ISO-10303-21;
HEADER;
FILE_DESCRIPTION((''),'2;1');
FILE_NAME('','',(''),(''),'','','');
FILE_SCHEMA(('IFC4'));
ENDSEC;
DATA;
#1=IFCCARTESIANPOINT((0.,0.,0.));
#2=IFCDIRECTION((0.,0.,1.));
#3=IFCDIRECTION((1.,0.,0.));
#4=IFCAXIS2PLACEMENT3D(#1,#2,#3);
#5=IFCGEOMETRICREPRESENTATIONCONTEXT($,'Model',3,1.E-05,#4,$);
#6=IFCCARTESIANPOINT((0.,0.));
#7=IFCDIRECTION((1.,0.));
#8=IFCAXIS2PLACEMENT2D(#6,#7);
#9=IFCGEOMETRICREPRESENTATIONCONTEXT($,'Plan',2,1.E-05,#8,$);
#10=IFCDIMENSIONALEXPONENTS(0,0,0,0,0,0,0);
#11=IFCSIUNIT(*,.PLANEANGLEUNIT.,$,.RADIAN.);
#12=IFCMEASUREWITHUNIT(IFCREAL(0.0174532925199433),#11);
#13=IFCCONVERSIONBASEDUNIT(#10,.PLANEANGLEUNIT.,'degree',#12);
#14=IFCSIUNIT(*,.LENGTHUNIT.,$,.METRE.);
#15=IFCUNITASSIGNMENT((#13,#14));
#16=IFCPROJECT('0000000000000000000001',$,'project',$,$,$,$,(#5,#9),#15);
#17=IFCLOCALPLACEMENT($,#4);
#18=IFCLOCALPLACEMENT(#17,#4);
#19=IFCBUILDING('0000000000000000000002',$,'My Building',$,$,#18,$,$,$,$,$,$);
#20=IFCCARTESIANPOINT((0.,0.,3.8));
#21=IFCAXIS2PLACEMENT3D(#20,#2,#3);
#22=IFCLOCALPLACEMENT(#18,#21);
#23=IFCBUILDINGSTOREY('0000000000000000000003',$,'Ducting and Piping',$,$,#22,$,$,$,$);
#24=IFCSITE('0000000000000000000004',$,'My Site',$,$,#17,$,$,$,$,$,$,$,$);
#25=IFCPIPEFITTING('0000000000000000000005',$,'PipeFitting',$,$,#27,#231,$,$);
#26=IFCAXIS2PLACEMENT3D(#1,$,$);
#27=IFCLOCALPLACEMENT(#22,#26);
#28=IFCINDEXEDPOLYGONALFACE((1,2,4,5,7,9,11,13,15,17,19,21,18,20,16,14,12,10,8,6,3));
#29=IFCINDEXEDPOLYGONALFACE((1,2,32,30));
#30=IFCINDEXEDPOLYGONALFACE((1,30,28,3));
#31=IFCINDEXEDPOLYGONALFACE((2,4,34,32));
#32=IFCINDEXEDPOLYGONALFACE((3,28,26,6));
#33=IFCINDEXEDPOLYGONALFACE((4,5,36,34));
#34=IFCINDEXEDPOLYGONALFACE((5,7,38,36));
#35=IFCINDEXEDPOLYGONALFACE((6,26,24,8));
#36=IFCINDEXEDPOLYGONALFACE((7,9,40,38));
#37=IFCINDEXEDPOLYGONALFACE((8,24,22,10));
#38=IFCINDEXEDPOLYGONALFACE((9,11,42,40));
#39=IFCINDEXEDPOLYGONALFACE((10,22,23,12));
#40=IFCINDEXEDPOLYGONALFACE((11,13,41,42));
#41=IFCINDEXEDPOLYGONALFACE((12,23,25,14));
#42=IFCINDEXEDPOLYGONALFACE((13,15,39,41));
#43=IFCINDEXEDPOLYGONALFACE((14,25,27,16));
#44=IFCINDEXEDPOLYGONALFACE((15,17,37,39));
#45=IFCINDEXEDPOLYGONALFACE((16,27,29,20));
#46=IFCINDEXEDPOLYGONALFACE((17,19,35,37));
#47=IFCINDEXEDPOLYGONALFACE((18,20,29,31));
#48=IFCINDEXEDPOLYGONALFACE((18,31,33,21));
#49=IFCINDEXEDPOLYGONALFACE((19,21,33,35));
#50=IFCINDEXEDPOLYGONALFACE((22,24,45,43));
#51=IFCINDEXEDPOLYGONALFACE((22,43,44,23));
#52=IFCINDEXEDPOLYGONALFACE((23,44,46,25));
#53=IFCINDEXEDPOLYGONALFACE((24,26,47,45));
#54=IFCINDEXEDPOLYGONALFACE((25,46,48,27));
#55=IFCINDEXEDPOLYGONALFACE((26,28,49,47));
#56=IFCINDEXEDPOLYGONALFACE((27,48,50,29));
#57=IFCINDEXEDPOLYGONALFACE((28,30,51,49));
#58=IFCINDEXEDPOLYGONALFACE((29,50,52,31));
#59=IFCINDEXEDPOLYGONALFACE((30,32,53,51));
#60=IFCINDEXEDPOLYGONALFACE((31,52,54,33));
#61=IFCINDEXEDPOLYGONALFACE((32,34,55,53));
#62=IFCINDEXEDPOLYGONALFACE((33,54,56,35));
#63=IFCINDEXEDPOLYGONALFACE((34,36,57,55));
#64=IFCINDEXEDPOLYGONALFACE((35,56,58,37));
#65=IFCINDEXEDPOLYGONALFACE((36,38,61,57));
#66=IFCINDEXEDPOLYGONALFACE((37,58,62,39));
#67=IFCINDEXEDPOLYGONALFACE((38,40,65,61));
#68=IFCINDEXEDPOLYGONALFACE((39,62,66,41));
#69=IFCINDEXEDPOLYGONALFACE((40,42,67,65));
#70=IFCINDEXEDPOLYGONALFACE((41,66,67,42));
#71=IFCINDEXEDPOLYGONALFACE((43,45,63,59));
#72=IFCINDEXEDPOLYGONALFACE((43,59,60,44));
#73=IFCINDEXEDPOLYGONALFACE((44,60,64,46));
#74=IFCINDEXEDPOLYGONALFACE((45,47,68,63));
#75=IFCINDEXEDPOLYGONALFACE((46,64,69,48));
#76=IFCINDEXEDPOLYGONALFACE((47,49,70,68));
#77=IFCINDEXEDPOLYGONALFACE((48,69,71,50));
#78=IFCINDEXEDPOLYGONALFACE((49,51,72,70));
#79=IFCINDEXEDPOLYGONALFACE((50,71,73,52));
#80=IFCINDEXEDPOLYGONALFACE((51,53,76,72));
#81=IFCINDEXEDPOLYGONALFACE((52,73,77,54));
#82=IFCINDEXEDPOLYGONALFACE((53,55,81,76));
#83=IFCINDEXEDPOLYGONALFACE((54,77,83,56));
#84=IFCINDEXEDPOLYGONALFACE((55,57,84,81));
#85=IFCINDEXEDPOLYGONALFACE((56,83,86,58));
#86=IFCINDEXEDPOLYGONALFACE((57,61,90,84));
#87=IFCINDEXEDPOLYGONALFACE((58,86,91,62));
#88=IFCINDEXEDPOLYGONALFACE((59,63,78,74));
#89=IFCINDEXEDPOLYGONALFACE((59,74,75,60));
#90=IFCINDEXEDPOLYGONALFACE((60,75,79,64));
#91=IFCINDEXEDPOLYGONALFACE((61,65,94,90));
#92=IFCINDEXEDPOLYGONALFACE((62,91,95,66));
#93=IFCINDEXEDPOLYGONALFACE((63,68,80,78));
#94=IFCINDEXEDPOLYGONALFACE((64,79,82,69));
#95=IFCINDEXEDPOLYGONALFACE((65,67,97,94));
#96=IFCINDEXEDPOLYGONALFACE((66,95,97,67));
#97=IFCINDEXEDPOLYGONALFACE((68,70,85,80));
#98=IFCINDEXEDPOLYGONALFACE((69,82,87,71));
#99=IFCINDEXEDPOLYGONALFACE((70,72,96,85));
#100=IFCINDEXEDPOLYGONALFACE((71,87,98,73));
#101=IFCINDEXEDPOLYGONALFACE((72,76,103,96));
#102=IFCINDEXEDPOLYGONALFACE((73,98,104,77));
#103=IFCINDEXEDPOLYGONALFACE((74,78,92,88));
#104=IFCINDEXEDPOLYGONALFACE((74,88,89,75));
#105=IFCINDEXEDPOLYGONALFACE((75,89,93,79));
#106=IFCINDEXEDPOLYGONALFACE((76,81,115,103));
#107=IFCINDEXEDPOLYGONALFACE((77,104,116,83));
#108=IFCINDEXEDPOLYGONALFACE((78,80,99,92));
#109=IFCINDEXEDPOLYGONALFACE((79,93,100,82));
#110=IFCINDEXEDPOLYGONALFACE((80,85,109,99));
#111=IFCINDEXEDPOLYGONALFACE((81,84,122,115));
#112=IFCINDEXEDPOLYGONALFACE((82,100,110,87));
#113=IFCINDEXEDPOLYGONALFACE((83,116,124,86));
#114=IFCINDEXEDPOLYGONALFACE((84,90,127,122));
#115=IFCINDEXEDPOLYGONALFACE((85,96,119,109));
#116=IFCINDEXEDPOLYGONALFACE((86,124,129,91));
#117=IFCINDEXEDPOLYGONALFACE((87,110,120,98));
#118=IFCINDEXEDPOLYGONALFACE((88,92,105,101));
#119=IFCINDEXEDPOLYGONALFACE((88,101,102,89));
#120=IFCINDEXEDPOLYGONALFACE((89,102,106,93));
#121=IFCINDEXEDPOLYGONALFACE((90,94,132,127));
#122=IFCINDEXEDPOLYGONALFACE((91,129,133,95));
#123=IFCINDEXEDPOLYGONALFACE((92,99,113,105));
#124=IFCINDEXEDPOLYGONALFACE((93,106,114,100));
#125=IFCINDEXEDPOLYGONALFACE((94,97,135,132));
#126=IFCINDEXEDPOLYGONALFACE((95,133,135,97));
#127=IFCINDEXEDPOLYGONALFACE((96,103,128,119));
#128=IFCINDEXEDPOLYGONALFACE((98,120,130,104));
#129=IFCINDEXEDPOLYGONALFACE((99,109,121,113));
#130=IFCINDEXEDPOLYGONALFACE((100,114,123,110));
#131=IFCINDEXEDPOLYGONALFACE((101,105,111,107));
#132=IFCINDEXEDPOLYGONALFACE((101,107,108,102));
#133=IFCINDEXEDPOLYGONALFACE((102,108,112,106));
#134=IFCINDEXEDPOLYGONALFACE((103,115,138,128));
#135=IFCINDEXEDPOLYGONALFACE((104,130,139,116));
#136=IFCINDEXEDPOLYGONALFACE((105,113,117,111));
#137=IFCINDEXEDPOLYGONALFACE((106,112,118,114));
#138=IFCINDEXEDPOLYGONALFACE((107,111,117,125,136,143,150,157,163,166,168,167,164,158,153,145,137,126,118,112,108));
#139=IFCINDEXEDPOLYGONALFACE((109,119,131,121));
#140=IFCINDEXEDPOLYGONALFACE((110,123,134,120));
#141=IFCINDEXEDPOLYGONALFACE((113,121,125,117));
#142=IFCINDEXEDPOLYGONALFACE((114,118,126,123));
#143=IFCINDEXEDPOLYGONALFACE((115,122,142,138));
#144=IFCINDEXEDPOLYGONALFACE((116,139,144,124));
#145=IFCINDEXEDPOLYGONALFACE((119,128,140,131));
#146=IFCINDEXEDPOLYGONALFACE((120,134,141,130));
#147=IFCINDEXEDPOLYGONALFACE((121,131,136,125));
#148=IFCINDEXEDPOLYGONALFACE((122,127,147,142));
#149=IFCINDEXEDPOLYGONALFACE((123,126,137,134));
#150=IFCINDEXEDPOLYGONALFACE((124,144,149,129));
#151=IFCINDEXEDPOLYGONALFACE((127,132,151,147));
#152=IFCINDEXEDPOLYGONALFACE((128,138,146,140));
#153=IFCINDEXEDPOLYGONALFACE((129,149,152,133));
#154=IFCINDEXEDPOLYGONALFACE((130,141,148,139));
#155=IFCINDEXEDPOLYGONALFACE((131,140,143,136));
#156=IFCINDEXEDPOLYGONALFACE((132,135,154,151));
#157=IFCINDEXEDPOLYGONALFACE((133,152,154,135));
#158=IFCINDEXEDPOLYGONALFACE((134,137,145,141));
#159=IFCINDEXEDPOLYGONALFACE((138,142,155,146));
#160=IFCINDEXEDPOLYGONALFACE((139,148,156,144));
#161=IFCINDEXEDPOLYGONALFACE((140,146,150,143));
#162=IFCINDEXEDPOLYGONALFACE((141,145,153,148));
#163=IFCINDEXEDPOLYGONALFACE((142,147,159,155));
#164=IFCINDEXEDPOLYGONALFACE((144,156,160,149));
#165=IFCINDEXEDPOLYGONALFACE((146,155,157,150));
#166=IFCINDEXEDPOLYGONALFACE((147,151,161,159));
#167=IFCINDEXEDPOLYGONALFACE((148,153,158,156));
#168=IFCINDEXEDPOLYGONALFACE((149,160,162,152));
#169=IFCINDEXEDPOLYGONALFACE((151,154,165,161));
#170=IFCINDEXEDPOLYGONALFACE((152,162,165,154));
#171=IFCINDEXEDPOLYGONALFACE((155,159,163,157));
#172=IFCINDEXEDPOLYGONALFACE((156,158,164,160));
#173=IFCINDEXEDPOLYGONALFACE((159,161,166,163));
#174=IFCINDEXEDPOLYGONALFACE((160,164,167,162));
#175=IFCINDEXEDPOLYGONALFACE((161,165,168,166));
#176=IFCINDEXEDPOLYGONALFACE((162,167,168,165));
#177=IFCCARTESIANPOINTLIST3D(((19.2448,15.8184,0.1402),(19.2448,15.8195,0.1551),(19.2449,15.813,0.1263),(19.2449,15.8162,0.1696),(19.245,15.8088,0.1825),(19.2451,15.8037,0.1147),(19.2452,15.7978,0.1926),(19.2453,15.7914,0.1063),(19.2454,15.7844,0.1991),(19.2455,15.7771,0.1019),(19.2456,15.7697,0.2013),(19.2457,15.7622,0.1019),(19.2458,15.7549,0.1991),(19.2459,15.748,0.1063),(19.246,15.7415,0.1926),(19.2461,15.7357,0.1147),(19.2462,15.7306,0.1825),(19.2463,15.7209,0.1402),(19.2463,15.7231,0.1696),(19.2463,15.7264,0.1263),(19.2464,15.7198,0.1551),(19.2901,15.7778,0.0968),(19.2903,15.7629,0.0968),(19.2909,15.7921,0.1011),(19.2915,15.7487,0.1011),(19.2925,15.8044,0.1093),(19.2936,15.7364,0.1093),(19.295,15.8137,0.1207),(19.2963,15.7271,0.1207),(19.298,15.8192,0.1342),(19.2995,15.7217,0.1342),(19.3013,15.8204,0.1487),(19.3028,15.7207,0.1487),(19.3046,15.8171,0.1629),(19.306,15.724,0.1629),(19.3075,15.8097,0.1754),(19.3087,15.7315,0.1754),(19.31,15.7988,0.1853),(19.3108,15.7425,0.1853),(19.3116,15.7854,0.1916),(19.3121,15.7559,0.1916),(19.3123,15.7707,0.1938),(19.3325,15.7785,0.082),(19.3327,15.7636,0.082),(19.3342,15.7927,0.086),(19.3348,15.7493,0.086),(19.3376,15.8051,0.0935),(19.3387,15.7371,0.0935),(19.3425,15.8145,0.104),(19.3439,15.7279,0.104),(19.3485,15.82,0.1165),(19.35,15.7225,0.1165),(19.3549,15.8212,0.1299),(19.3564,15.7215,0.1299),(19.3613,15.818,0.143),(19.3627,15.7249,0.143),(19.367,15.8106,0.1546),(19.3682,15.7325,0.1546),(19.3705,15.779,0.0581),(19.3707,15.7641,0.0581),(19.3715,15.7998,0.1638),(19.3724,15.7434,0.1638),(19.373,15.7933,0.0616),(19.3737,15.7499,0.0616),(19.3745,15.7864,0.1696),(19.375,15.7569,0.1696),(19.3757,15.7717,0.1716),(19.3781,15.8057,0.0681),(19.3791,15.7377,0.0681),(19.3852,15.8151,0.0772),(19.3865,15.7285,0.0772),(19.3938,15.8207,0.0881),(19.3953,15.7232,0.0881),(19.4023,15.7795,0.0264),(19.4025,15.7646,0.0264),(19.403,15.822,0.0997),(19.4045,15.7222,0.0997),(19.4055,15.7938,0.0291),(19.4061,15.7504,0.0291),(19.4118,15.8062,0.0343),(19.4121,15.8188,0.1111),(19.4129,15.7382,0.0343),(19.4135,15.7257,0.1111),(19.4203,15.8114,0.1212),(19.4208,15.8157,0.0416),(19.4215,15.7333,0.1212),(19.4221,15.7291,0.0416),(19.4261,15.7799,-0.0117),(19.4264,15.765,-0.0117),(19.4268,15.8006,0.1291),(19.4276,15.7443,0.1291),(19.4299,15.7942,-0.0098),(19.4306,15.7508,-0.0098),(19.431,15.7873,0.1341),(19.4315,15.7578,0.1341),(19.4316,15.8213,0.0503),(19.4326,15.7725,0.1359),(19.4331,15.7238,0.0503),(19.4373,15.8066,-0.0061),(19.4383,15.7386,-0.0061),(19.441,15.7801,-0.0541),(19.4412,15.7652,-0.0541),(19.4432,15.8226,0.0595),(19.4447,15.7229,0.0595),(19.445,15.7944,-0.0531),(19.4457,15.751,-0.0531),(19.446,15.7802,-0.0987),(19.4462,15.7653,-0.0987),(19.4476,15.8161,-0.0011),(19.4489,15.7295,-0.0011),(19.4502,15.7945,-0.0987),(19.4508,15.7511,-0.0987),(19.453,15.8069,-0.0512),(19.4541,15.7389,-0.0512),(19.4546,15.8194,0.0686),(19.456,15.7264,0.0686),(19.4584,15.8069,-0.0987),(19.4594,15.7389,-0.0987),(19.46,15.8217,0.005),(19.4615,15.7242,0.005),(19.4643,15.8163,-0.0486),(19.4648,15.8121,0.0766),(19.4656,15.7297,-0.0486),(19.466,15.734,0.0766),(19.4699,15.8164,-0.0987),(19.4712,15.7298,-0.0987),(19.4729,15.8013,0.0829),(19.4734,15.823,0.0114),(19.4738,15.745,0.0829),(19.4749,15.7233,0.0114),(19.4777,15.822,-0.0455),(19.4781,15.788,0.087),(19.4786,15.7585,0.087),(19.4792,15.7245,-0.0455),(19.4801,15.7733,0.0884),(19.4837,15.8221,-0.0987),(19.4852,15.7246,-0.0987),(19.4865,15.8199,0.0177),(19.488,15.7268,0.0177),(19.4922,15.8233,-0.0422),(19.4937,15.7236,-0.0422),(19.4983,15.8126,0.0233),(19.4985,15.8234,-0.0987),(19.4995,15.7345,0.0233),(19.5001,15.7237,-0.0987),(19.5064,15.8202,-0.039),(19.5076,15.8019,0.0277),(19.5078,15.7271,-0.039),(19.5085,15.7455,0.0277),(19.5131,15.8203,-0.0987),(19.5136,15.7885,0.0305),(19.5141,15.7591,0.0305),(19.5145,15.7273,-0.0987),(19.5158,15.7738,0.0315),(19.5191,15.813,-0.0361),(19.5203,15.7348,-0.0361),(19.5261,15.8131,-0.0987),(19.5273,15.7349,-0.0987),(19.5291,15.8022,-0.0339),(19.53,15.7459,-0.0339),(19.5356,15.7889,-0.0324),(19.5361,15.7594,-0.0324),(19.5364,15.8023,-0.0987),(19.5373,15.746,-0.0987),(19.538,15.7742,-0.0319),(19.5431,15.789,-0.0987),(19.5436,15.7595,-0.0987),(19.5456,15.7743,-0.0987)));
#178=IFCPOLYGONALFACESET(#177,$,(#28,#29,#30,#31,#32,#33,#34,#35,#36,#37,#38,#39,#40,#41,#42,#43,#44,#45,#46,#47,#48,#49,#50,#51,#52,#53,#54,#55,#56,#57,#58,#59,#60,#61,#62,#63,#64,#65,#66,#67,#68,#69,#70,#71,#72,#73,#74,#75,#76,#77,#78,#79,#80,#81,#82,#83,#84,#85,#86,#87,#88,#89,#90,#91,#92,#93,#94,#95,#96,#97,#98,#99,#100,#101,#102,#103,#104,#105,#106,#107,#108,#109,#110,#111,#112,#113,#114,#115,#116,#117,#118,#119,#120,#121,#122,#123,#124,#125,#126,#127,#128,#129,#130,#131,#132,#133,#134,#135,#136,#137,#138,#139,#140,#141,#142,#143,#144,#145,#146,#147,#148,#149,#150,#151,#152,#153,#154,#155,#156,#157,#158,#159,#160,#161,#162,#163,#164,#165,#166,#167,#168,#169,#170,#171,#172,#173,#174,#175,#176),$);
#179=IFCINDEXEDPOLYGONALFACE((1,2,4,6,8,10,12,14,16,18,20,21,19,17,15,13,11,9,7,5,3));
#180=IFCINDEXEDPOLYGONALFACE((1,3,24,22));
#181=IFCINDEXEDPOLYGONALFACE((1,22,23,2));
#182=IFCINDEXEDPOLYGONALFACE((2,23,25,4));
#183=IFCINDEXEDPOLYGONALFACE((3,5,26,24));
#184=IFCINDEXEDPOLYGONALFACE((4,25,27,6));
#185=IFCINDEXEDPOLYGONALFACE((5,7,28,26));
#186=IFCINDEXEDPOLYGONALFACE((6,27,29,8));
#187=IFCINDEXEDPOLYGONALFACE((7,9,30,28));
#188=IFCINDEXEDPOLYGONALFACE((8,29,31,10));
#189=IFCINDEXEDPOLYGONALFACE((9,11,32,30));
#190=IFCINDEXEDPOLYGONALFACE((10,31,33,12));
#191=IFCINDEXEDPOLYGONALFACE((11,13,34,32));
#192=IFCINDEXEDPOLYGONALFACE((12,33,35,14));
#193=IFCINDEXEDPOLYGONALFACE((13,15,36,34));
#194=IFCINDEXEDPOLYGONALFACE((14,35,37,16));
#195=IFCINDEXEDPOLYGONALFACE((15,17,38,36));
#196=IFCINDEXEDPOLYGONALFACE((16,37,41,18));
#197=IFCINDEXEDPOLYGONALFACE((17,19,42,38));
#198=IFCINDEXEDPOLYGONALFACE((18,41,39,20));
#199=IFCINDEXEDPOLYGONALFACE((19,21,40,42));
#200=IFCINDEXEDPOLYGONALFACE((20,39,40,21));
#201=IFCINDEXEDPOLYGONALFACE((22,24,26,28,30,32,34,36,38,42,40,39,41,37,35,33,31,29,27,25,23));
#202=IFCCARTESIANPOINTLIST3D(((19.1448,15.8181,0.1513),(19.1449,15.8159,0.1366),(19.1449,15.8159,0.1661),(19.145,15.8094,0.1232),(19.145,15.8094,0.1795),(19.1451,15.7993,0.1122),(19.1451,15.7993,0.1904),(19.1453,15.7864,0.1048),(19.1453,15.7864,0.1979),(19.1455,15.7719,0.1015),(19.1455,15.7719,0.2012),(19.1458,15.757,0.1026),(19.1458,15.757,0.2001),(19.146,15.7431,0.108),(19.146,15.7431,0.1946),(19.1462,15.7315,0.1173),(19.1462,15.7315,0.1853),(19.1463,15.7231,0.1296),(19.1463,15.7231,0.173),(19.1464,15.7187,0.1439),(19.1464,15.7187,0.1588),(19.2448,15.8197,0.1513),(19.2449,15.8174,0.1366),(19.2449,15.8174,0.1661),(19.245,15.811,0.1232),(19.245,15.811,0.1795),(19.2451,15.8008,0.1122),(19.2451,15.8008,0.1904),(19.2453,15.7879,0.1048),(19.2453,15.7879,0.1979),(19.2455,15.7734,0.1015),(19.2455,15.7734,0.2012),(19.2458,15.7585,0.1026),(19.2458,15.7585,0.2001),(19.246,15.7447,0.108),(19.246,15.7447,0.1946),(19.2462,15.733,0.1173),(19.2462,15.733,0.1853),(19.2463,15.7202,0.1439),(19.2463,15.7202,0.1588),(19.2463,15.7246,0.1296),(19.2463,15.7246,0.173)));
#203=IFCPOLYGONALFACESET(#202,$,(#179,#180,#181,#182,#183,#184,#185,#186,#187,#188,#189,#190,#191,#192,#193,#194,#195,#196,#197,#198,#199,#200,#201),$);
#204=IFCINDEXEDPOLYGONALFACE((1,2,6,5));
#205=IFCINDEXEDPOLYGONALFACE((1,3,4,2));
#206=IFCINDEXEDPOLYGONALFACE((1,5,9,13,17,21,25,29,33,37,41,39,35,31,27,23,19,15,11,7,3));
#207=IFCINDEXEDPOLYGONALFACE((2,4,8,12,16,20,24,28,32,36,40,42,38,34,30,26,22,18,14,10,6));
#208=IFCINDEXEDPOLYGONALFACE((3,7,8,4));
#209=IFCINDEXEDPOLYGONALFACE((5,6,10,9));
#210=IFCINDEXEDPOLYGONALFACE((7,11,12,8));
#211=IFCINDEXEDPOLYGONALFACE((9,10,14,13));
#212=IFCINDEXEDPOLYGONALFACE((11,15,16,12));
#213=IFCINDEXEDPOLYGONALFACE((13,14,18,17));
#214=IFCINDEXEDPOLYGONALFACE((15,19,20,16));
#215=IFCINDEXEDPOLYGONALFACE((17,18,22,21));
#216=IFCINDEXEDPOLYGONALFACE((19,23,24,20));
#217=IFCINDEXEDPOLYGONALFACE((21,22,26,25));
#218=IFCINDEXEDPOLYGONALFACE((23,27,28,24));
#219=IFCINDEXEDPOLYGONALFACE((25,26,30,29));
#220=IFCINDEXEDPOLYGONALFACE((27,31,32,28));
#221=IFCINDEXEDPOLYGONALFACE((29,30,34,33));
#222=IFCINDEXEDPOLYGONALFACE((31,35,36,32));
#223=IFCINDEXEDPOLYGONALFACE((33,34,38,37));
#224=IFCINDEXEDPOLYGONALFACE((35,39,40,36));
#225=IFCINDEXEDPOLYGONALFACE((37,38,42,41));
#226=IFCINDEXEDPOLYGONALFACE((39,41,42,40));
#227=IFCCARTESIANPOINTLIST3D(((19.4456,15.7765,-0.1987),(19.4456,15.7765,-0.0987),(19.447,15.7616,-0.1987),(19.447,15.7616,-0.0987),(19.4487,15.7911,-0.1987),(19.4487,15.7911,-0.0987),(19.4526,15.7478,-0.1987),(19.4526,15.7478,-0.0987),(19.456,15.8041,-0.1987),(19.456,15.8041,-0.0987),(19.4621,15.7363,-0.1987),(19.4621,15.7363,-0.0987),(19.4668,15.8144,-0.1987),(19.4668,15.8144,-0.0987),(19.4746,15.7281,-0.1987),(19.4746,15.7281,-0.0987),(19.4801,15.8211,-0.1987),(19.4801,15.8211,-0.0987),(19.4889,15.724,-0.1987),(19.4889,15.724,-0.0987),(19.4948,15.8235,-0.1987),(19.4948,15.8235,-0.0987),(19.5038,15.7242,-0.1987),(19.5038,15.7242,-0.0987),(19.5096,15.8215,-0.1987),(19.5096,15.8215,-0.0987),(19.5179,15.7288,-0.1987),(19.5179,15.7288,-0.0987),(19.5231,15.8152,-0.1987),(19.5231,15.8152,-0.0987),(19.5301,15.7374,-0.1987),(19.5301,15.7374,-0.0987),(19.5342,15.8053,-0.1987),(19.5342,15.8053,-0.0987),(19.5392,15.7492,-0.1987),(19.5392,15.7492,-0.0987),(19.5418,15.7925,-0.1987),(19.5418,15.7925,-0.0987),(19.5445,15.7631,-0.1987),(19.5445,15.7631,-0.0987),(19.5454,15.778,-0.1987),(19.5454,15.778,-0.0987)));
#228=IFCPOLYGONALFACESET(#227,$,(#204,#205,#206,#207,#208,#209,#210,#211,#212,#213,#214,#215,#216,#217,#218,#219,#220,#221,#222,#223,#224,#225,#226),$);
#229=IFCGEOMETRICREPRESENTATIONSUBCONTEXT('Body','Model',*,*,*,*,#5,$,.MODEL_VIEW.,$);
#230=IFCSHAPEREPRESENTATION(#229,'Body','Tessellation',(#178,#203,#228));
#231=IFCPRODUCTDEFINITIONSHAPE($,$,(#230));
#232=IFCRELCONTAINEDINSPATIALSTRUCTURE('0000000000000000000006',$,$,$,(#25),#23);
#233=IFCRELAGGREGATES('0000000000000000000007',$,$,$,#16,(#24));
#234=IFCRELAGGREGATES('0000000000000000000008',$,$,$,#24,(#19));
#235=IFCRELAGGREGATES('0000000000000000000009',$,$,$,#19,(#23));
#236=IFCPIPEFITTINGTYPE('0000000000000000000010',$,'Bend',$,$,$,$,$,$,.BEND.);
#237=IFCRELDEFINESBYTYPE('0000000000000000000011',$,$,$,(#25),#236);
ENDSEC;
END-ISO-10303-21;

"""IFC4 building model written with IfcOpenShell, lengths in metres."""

from ifc_helpers import new_model, entity, si_unit, converted_unit, frame, origin_with_axes, origin_2d_with_axis, place, context, subcontext, project, spatial, circle, extrude, source, transform, mapped, type_object, type_shapes, element, save


model = new_model("IFC4")

# Units and contexts
model_context = context("Model", 3, precision=1e-05, world=origin_with_axes())
plan_context = context("Plan", 2, precision=1e-05, world=origin_2d_with_axis())
body_context = subcontext(model_context, "Body", "Model", "MODEL_VIEW")
ifc_project = project(units=[converted_unit("PLANEANGLEUNIT", "degree", entity("IfcReal", 0.0174532925199433), si_unit("PLANEANGLEUNIT", "RADIAN"), dimensions=[0, 0, 0, 0, 0, 0, 0]), si_unit("LENGTHUNIT", "METRE")], contexts=[model_context, plan_context])

# Site, building, storey
site_placement = place(None, origin_with_axes())
site = spatial("IfcSite", under=ifc_project, at=site_placement, Name="My Site")
building_placement = place(site_placement, origin_with_axes())
building = spatial("IfcBuilding", under=site, at=building_placement, Name="My Building")
storey_placement = place(building_placement, frame((0.0, 0.0, 3.8), z_axis=(0.0, 0.0, 1.0), x_axis=(1.0, 0.0, 0.0)))
storey = spatial("IfcBuildingStorey", under=building, at=storey_placement, Name="Ducting and Piping")

# Pipe fitting
pipe_fitting_type = type_object("IfcPipeFittingType", Name="Bend", PredefinedType="BEND")
shared_shape = source(origin_with_axes(), body_context, "Body", "SolidModel", [
    entity("IfcSweptDiskSolid", entity("IfcIndexedPolyCurve", entity("IfcCartesianPointList3D", [[0.0, 0.0, 0.1], [0.0, -0.0732, 0.2768], [0.0, -0.25, 0.35]]), [entity("IfcArcIndex", [1, 2, 3])]), 0.05),
    extrude(circle(Radius=0.05), origin_with_axes(), (0.0, 0.0, 1.0), 0.1),
    extrude(circle(Radius=0.05), frame((0.0, -0.25, 0.35), z_axis=(0.0, -1.0, 0.0), x_axis=(1.0, 0.0, 0.0)), (0.0, 0.0, 1.0), 0.1),
])
type_shapes(pipe_fitting_type, [shared_shape])
for number, where, z_axis, x_axis, name in (
    (1, (19.1456, 15.7681, 0.1513), (0.999882, 0.015371, 0.0), (-0.015371, 0.999882, 0.0), "PipeFitting"),
):
    element("IfcPipeFitting", number, at=place(storey_placement, frame(where, z_axis=z_axis, x_axis=x_axis)), inside=storey, type_object=pipe_fitting_type, Name=name, context=body_context, shape_type="MappedRepresentation", body=[
        mapped(shared_shape, transform((0.0, 0.0, 0.0), x_axis=(1.0, 0.0, 0.0), y_axis=(0.0, 1.0, 0.0), z_axis=(0.0, 0.0, 1.0), scale=1.0)),
    ])

save(model, "model.ifc")
